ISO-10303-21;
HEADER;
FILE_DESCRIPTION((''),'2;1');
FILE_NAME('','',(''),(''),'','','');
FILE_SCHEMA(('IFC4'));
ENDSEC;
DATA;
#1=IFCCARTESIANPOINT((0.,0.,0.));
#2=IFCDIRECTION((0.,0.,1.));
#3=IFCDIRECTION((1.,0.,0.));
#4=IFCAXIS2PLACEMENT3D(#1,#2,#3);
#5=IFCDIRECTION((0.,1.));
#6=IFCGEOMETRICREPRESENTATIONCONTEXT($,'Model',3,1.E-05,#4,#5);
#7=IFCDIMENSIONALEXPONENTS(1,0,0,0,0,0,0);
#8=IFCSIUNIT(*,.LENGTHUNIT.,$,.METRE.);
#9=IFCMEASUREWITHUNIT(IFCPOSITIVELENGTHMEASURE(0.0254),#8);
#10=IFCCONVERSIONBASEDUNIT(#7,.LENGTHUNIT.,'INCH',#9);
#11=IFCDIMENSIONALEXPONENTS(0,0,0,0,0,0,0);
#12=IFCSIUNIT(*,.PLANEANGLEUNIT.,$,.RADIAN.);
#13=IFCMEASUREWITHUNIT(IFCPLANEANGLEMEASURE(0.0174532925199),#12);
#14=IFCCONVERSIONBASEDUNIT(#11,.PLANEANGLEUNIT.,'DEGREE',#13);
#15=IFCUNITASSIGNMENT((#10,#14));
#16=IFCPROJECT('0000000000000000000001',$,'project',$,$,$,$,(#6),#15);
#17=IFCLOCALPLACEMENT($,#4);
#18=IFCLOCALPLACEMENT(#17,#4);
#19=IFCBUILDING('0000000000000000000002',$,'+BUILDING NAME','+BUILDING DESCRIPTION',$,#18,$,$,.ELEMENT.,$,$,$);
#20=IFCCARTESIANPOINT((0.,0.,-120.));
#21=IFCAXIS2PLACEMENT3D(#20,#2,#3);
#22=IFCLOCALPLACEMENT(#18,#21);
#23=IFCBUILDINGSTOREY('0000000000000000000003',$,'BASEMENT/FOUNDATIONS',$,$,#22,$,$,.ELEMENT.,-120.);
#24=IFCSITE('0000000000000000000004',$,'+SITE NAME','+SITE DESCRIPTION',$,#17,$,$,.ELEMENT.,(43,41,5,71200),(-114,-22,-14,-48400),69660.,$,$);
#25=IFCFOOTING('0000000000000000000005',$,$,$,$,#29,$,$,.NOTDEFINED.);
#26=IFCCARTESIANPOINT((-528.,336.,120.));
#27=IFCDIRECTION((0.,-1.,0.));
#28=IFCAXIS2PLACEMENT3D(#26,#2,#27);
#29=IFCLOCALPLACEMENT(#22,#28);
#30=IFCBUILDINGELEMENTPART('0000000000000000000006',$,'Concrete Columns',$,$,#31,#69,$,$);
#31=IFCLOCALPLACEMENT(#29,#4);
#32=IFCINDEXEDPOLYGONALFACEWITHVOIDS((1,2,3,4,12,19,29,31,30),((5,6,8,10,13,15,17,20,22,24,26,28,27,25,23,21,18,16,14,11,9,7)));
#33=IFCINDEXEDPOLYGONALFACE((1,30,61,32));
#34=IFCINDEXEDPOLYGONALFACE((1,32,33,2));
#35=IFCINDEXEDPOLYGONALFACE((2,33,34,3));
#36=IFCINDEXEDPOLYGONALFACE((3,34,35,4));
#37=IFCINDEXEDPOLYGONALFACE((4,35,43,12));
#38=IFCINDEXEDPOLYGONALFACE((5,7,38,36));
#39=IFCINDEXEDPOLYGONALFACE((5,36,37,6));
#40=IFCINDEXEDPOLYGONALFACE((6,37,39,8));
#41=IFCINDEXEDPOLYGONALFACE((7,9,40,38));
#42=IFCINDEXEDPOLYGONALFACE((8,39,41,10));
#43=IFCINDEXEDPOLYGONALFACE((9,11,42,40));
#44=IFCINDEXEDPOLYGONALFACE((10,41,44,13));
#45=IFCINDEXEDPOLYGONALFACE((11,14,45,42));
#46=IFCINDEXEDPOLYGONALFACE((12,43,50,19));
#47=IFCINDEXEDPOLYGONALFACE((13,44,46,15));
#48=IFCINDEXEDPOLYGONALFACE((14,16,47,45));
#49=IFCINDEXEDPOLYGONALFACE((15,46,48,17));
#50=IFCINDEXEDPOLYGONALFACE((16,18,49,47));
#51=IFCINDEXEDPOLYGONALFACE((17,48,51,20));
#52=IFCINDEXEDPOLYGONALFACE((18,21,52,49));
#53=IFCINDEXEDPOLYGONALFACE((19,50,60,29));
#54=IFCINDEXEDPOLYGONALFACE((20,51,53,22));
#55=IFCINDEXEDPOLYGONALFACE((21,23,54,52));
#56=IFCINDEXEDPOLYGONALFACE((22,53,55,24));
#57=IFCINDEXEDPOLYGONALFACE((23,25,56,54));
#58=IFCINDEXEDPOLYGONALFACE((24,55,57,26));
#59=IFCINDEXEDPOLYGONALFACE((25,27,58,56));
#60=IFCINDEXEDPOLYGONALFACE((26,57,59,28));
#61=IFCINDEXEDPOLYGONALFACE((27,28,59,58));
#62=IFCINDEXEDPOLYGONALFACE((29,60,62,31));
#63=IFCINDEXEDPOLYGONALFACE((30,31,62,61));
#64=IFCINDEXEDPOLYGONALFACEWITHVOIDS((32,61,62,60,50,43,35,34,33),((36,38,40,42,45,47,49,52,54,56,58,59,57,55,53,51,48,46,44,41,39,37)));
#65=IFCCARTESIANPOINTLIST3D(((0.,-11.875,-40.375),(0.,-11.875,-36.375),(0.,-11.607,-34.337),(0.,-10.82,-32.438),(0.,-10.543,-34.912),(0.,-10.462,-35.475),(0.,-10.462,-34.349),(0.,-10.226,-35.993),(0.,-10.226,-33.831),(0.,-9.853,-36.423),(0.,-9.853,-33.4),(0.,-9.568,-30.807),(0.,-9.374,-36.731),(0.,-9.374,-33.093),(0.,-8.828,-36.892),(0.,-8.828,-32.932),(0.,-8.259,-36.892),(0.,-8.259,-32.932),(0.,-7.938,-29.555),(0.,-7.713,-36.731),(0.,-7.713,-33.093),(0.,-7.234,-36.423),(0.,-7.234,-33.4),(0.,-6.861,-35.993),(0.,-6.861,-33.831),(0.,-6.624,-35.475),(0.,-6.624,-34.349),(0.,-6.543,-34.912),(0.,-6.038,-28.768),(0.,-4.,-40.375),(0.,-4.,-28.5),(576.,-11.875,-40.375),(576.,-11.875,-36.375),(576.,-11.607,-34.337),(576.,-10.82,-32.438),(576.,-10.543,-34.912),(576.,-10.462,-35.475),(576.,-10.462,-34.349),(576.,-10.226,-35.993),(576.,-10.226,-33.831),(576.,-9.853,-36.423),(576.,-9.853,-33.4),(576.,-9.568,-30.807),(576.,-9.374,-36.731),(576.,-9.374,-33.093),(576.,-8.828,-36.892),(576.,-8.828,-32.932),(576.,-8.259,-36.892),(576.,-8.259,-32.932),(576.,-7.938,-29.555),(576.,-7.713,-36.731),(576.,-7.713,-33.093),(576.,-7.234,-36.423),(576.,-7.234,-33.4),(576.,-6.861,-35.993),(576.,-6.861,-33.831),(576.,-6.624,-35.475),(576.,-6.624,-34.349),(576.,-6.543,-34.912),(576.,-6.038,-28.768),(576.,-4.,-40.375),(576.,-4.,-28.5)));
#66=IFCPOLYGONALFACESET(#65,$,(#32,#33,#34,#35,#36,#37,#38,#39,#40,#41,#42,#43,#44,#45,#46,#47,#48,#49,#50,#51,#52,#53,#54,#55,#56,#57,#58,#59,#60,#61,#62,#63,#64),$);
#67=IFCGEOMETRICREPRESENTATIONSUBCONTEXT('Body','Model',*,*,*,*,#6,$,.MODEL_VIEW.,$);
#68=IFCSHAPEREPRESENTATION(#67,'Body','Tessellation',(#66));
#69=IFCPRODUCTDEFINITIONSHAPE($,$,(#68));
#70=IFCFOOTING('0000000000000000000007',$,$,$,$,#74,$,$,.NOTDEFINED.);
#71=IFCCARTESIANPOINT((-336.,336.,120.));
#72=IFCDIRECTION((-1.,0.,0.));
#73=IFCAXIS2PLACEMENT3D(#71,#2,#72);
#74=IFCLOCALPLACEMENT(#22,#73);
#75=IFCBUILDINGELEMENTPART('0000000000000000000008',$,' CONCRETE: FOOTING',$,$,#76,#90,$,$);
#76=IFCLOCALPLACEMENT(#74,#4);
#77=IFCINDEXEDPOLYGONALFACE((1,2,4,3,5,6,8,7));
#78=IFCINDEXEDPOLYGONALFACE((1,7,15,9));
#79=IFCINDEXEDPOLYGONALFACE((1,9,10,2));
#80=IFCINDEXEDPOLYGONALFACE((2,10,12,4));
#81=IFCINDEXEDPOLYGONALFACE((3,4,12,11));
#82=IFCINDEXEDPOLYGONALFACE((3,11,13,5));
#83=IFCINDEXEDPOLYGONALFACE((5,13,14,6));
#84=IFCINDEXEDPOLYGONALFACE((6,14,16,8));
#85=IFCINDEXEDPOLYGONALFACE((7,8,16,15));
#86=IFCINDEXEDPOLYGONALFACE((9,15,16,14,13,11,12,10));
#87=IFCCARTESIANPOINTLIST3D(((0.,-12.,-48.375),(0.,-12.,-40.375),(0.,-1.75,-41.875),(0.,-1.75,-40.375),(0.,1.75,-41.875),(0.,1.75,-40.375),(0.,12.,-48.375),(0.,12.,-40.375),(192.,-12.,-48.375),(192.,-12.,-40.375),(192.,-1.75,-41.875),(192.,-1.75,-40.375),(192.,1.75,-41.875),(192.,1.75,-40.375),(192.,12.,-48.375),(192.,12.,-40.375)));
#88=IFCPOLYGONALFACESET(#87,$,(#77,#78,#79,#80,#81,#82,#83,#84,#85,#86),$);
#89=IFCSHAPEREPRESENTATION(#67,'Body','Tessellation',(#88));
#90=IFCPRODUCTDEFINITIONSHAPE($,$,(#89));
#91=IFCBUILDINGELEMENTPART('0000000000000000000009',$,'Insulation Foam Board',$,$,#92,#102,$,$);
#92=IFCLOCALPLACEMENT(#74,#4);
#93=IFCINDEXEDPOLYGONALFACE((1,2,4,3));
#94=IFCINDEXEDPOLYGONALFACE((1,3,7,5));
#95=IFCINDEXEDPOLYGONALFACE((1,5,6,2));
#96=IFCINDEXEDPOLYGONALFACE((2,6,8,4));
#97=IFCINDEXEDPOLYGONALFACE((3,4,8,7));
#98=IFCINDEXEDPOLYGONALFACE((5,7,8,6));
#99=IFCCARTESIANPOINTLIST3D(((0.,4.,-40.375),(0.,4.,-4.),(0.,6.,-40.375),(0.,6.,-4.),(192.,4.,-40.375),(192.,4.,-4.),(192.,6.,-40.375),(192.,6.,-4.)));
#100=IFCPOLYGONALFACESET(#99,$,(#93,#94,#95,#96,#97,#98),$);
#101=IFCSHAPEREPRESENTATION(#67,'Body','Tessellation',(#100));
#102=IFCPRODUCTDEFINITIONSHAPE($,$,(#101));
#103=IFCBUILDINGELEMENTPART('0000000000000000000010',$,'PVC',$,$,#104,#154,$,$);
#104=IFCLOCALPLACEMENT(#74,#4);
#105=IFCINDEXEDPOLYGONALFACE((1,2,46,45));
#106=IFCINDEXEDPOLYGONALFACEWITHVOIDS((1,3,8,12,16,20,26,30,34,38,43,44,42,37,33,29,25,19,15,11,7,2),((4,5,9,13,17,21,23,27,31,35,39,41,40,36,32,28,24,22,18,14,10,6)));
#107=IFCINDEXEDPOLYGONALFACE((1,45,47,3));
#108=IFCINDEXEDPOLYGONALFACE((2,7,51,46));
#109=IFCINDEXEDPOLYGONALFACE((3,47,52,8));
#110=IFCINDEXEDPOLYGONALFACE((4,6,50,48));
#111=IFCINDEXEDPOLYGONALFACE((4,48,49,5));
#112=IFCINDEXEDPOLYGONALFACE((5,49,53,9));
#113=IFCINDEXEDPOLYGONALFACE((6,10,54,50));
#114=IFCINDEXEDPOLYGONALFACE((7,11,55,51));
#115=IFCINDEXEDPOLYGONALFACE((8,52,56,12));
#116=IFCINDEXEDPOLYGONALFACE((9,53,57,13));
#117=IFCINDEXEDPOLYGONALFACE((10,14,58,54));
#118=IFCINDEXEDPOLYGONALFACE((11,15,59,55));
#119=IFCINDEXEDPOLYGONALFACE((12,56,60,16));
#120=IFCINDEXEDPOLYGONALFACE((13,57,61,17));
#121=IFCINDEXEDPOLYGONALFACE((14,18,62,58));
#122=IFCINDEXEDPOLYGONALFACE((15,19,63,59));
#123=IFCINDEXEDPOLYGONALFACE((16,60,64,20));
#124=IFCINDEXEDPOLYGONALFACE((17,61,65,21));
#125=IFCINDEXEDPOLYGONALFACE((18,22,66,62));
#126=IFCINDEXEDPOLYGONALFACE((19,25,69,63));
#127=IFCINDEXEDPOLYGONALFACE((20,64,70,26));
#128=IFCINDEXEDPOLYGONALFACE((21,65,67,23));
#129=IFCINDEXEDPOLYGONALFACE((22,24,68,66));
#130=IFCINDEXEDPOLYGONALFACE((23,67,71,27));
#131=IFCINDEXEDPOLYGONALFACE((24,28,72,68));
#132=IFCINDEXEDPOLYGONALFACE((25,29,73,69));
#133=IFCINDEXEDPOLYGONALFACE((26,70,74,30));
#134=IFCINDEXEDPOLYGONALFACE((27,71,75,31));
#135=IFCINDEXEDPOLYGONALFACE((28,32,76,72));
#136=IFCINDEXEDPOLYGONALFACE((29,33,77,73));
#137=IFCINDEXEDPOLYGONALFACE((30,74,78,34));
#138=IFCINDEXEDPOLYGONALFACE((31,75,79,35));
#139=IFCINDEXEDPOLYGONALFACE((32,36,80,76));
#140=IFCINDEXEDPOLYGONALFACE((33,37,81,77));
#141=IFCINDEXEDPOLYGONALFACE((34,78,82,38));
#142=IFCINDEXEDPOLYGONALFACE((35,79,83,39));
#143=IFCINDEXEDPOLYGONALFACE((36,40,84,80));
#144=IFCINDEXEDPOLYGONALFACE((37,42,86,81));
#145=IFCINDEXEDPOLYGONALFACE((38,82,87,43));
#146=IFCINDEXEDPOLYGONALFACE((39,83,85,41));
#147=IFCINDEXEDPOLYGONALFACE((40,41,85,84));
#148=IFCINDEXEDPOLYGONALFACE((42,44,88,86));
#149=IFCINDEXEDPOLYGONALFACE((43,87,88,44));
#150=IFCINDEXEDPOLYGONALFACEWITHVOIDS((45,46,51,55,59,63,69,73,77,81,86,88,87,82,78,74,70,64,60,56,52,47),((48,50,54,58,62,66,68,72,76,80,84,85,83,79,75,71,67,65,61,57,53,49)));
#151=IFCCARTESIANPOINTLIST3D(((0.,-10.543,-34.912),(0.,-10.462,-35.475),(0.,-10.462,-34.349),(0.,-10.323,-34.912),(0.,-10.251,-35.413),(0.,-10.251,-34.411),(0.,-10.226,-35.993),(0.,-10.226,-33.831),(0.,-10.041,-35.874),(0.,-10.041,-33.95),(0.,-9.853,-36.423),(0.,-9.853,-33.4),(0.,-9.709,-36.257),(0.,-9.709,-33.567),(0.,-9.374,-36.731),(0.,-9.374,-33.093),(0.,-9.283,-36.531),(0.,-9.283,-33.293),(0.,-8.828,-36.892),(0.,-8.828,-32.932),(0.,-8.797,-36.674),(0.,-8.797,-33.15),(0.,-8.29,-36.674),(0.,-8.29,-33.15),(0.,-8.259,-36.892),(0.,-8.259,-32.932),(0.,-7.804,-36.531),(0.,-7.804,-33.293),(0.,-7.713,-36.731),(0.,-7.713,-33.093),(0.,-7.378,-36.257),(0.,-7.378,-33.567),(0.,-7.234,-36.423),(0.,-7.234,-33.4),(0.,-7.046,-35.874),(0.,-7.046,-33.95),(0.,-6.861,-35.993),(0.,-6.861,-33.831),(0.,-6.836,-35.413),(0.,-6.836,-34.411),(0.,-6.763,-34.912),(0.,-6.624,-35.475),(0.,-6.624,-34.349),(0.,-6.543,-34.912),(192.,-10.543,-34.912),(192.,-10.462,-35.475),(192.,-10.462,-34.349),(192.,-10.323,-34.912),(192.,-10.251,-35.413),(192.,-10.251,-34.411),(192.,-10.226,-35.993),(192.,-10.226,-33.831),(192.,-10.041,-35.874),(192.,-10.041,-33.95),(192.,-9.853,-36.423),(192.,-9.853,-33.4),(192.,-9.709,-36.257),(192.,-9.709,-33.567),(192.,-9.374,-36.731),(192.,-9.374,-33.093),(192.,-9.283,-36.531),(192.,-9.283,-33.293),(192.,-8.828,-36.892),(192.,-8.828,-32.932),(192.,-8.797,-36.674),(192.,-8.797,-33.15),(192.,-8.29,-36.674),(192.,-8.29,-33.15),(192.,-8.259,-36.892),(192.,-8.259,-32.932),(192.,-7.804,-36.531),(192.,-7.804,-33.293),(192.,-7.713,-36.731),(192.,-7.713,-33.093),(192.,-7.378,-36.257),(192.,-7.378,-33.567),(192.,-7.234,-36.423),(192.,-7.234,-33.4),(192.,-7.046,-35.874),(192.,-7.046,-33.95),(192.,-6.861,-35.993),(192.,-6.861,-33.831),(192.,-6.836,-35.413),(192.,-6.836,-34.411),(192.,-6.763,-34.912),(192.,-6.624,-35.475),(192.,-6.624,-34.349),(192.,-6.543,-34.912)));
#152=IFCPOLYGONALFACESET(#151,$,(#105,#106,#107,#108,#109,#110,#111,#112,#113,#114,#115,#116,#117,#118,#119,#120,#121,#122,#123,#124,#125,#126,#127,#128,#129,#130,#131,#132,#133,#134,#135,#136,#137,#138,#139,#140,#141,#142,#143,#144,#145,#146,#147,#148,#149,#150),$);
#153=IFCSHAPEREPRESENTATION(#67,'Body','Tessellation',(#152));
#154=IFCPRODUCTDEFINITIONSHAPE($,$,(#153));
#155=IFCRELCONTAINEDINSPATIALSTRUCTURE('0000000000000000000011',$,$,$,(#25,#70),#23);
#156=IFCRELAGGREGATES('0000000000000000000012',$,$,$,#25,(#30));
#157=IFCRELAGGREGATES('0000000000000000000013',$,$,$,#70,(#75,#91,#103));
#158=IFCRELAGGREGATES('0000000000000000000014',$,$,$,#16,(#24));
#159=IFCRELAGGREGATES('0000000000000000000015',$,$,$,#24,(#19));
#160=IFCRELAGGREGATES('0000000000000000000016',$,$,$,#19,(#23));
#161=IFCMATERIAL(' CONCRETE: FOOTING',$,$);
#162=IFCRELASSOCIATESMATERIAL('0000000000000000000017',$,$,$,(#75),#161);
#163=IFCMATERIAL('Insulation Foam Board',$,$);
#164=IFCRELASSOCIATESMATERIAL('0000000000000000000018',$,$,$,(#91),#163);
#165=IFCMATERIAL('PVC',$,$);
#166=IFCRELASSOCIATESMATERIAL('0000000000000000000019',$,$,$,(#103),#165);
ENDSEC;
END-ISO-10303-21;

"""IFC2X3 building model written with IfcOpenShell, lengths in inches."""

from ifc_helpers import new_model, entity, si_unit, converted_unit, point, direction, frame, frame_2d, origin_with_axes, place, context, subcontext, project, spatial, polyline, circle_curve, parameter, trimmed, segment, composite_curve, outline, extrude, material, element, aggregate, save


model = new_model("IFC2X3")

# Units and contexts
model_context = context("Model", 3, precision=1e-05, world=origin_with_axes(), true_north=direction((0.0, 1.0)))
body_context = subcontext(model_context, "Body", "Model", "MODEL_VIEW")
ifc_project = project(units=[converted_unit("LENGTHUNIT", "INCH", entity("IfcPositiveLengthMeasure", 0.0254), si_unit("LENGTHUNIT", "METRE"), dimensions=[1, 0, 0, 0, 0, 0, 0]), converted_unit("PLANEANGLEUNIT", "DEGREE", entity("IfcPlaneAngleMeasure", 0.0174532925199), si_unit("PLANEANGLEUNIT", "RADIAN"), dimensions=[0, 0, 0, 0, 0, 0, 0])], contexts=[model_context])

# Site, building, storey
site_placement = place(None, origin_with_axes())
site = spatial("IfcSite", under=ifc_project, at=site_placement, Name="+SITE NAME", Description="+SITE DESCRIPTION", CompositionType="ELEMENT", RefLatitude=(43, 41, 5, 71200), RefLongitude=(-114, -22, -14, -48400), RefElevation=69660.0)
building_placement = place(site_placement, origin_with_axes())
building = spatial("IfcBuilding", under=site, at=building_placement, Name="+BUILDING NAME", Description="+BUILDING DESCRIPTION", CompositionType="ELEMENT")
storey_placement = place(building_placement, frame((0.0, 0.0, -120.0), z_axis=(0.0, 0.0, 1.0), x_axis=(1.0, 0.0, 0.0)))
storey = spatial("IfcBuildingStorey", under=building, at=storey_placement, Name="BASEMENT/FOUNDATIONS", CompositionType="ELEMENT", Elevation=-120.0)

# Footings, building element parts
ifc_material_1 = material(Name=" CONCRETE: FOOTING")
ifc_material_2 = material(Name="Insulation Foam Board")
ifc_material_3 = material(Name="PVC")
footing_1_placement = place(storey_placement, frame((-528.0, 336.0, 120.0), z_axis=(0.0, 0.0, 1.0), x_axis=(0.0, -1.0, 0.0)))
footing_1 = element("IfcFooting", 1, at=footing_1_placement, inside=storey, PredefinedType="NOTDEFINED")
building_element_part_1_placement = place(footing_1_placement, origin_with_axes())
building_element_part_1 = element("IfcBuildingElementPart", 2, at=building_element_part_1_placement, Name="Concrete Columns", context=body_context, shape_type="SweptSolid", body=[
    extrude(outline(composite_curve([segment(trimmed(circle_curve(frame_2d((4.0, -36.375), x_axis=(1.0, 0.0)), 7.875), [point((11.875, -36.375)), parameter(0.0)], [point((4.0, -28.5)), parameter(90.0)], True, "CARTESIAN"), True, "CONTINUOUS"), segment(polyline([(4.0, -28.5), (4.0, -40.375), (11.875, -40.375), (11.875, -36.375)]), True, "CONTINUOUS")], self_intersect=False), holes=[composite_curve([segment(trimmed(circle_curve(frame_2d((8.543, -34.912), x_axis=(-1.0, 0.0)), 2.0), [point((10.543, -34.912)), parameter(180.0)], [point((6.543, -34.912)), parameter(0.0)], False, "CARTESIAN"), True, "CONTINUOUS"), segment(trimmed(circle_curve(frame_2d((8.543, -34.912), x_axis=(1.0, 0.0)), 2.0), [point((6.543, -34.912)), parameter(180.0)], [point((10.543, -34.912)), parameter(0.0)], False, "CARTESIAN"), True, "CONTINUOUS")], self_intersect=False)]), frame((0.0, 0.0, 0.0), z_axis=(-1.0, 0.0, 0.0), x_axis=(0.0, -1.0, 0.0)), (0.0, 0.0, -1.0), 576.0),
])
aggregate(footing_1, [building_element_part_1])
footing_2_placement = place(storey_placement, frame((-336.0, 336.0, 120.0), z_axis=(0.0, 0.0, 1.0), x_axis=(-1.0, 0.0, 0.0)))
footing_2 = element("IfcFooting", 3, at=footing_2_placement, inside=storey, PredefinedType="NOTDEFINED")
building_element_part_2_placement = place(footing_2_placement, origin_with_axes())
building_element_part_2 = element("IfcBuildingElementPart", 4, at=building_element_part_2_placement, material=ifc_material_1, Name=" CONCRETE: FOOTING", context=body_context, shape_type="SweptSolid", body=[
    extrude(outline(polyline([(-12.0, -48.375), (12.0, -48.375), (12.0, -40.375), (1.75, -40.375), (1.75, -41.875), (-1.75, -41.875), (-1.75, -40.375), (-12.0, -40.375), (-12.0, -48.375)])), frame((0.0, 0.0, 0.0), z_axis=(-1.0, 0.0, 0.0), x_axis=(0.0, -1.0, 0.0)), (0.0, 0.0, -1.0), 192.0),
])
building_element_part_3_placement = place(footing_2_placement, origin_with_axes())
building_element_part_3 = element("IfcBuildingElementPart", 5, at=building_element_part_3_placement, material=ifc_material_2, Name="Insulation Foam Board", context=body_context, shape_type="SweptSolid", body=[
    extrude(outline(polyline([(-4.0, -4.0), (-6.0, -4.0), (-6.0, -40.375), (-4.0, -40.375), (-4.0, -4.0)])), frame((0.0, 0.0, 0.0), z_axis=(-1.0, 0.0, 0.0), x_axis=(0.0, -1.0, 0.0)), (0.0, 0.0, -1.0), 192.0),
])
building_element_part_4_placement = place(footing_2_placement, origin_with_axes())
building_element_part_4 = element("IfcBuildingElementPart", 6, at=building_element_part_4_placement, material=ifc_material_3, Name="PVC", context=body_context, shape_type="SweptSolid", body=[
    extrude(outline(composite_curve([segment(trimmed(circle_curve(frame_2d((8.543, -34.912), x_axis=(1.0, 0.0)), 2.0), [point((10.543, -34.912)), parameter(0.0)], [point((6.543, -34.912)), parameter(180.0)], True, "CARTESIAN"), True, "CONTINUOUS"), segment(trimmed(circle_curve(frame_2d((8.543, -34.912), x_axis=(-1.0, 0.0)), 2.0), [point((6.543, -34.912)), parameter(0.0)], [point((10.543, -34.912)), parameter(180.0)], True, "CARTESIAN"), True, "CONTINUOUS")], self_intersect=False), holes=[composite_curve([segment(trimmed(circle_curve(frame_2d((8.543, -34.912), x_axis=(-1.0, 0.0)), 1.78), [point((10.323, -34.912)), parameter(180.0)], [point((6.763, -34.912)), parameter(0.0)], False, "CARTESIAN"), True, "CONTINUOUS"), segment(trimmed(circle_curve(frame_2d((8.543, -34.912), x_axis=(1.0, 0.0)), 1.78), [point((6.763, -34.912)), parameter(180.0)], [point((10.323, -34.912)), parameter(0.0)], False, "CARTESIAN"), True, "CONTINUOUS")], self_intersect=False)]), frame((0.0, 0.0, 0.0), z_axis=(-1.0, 0.0, 0.0), x_axis=(0.0, -1.0, 0.0)), (0.0, 0.0, -1.0), 192.0),
])
aggregate(footing_2, [building_element_part_2, building_element_part_3, building_element_part_4])

save(model, "model.ifc")
